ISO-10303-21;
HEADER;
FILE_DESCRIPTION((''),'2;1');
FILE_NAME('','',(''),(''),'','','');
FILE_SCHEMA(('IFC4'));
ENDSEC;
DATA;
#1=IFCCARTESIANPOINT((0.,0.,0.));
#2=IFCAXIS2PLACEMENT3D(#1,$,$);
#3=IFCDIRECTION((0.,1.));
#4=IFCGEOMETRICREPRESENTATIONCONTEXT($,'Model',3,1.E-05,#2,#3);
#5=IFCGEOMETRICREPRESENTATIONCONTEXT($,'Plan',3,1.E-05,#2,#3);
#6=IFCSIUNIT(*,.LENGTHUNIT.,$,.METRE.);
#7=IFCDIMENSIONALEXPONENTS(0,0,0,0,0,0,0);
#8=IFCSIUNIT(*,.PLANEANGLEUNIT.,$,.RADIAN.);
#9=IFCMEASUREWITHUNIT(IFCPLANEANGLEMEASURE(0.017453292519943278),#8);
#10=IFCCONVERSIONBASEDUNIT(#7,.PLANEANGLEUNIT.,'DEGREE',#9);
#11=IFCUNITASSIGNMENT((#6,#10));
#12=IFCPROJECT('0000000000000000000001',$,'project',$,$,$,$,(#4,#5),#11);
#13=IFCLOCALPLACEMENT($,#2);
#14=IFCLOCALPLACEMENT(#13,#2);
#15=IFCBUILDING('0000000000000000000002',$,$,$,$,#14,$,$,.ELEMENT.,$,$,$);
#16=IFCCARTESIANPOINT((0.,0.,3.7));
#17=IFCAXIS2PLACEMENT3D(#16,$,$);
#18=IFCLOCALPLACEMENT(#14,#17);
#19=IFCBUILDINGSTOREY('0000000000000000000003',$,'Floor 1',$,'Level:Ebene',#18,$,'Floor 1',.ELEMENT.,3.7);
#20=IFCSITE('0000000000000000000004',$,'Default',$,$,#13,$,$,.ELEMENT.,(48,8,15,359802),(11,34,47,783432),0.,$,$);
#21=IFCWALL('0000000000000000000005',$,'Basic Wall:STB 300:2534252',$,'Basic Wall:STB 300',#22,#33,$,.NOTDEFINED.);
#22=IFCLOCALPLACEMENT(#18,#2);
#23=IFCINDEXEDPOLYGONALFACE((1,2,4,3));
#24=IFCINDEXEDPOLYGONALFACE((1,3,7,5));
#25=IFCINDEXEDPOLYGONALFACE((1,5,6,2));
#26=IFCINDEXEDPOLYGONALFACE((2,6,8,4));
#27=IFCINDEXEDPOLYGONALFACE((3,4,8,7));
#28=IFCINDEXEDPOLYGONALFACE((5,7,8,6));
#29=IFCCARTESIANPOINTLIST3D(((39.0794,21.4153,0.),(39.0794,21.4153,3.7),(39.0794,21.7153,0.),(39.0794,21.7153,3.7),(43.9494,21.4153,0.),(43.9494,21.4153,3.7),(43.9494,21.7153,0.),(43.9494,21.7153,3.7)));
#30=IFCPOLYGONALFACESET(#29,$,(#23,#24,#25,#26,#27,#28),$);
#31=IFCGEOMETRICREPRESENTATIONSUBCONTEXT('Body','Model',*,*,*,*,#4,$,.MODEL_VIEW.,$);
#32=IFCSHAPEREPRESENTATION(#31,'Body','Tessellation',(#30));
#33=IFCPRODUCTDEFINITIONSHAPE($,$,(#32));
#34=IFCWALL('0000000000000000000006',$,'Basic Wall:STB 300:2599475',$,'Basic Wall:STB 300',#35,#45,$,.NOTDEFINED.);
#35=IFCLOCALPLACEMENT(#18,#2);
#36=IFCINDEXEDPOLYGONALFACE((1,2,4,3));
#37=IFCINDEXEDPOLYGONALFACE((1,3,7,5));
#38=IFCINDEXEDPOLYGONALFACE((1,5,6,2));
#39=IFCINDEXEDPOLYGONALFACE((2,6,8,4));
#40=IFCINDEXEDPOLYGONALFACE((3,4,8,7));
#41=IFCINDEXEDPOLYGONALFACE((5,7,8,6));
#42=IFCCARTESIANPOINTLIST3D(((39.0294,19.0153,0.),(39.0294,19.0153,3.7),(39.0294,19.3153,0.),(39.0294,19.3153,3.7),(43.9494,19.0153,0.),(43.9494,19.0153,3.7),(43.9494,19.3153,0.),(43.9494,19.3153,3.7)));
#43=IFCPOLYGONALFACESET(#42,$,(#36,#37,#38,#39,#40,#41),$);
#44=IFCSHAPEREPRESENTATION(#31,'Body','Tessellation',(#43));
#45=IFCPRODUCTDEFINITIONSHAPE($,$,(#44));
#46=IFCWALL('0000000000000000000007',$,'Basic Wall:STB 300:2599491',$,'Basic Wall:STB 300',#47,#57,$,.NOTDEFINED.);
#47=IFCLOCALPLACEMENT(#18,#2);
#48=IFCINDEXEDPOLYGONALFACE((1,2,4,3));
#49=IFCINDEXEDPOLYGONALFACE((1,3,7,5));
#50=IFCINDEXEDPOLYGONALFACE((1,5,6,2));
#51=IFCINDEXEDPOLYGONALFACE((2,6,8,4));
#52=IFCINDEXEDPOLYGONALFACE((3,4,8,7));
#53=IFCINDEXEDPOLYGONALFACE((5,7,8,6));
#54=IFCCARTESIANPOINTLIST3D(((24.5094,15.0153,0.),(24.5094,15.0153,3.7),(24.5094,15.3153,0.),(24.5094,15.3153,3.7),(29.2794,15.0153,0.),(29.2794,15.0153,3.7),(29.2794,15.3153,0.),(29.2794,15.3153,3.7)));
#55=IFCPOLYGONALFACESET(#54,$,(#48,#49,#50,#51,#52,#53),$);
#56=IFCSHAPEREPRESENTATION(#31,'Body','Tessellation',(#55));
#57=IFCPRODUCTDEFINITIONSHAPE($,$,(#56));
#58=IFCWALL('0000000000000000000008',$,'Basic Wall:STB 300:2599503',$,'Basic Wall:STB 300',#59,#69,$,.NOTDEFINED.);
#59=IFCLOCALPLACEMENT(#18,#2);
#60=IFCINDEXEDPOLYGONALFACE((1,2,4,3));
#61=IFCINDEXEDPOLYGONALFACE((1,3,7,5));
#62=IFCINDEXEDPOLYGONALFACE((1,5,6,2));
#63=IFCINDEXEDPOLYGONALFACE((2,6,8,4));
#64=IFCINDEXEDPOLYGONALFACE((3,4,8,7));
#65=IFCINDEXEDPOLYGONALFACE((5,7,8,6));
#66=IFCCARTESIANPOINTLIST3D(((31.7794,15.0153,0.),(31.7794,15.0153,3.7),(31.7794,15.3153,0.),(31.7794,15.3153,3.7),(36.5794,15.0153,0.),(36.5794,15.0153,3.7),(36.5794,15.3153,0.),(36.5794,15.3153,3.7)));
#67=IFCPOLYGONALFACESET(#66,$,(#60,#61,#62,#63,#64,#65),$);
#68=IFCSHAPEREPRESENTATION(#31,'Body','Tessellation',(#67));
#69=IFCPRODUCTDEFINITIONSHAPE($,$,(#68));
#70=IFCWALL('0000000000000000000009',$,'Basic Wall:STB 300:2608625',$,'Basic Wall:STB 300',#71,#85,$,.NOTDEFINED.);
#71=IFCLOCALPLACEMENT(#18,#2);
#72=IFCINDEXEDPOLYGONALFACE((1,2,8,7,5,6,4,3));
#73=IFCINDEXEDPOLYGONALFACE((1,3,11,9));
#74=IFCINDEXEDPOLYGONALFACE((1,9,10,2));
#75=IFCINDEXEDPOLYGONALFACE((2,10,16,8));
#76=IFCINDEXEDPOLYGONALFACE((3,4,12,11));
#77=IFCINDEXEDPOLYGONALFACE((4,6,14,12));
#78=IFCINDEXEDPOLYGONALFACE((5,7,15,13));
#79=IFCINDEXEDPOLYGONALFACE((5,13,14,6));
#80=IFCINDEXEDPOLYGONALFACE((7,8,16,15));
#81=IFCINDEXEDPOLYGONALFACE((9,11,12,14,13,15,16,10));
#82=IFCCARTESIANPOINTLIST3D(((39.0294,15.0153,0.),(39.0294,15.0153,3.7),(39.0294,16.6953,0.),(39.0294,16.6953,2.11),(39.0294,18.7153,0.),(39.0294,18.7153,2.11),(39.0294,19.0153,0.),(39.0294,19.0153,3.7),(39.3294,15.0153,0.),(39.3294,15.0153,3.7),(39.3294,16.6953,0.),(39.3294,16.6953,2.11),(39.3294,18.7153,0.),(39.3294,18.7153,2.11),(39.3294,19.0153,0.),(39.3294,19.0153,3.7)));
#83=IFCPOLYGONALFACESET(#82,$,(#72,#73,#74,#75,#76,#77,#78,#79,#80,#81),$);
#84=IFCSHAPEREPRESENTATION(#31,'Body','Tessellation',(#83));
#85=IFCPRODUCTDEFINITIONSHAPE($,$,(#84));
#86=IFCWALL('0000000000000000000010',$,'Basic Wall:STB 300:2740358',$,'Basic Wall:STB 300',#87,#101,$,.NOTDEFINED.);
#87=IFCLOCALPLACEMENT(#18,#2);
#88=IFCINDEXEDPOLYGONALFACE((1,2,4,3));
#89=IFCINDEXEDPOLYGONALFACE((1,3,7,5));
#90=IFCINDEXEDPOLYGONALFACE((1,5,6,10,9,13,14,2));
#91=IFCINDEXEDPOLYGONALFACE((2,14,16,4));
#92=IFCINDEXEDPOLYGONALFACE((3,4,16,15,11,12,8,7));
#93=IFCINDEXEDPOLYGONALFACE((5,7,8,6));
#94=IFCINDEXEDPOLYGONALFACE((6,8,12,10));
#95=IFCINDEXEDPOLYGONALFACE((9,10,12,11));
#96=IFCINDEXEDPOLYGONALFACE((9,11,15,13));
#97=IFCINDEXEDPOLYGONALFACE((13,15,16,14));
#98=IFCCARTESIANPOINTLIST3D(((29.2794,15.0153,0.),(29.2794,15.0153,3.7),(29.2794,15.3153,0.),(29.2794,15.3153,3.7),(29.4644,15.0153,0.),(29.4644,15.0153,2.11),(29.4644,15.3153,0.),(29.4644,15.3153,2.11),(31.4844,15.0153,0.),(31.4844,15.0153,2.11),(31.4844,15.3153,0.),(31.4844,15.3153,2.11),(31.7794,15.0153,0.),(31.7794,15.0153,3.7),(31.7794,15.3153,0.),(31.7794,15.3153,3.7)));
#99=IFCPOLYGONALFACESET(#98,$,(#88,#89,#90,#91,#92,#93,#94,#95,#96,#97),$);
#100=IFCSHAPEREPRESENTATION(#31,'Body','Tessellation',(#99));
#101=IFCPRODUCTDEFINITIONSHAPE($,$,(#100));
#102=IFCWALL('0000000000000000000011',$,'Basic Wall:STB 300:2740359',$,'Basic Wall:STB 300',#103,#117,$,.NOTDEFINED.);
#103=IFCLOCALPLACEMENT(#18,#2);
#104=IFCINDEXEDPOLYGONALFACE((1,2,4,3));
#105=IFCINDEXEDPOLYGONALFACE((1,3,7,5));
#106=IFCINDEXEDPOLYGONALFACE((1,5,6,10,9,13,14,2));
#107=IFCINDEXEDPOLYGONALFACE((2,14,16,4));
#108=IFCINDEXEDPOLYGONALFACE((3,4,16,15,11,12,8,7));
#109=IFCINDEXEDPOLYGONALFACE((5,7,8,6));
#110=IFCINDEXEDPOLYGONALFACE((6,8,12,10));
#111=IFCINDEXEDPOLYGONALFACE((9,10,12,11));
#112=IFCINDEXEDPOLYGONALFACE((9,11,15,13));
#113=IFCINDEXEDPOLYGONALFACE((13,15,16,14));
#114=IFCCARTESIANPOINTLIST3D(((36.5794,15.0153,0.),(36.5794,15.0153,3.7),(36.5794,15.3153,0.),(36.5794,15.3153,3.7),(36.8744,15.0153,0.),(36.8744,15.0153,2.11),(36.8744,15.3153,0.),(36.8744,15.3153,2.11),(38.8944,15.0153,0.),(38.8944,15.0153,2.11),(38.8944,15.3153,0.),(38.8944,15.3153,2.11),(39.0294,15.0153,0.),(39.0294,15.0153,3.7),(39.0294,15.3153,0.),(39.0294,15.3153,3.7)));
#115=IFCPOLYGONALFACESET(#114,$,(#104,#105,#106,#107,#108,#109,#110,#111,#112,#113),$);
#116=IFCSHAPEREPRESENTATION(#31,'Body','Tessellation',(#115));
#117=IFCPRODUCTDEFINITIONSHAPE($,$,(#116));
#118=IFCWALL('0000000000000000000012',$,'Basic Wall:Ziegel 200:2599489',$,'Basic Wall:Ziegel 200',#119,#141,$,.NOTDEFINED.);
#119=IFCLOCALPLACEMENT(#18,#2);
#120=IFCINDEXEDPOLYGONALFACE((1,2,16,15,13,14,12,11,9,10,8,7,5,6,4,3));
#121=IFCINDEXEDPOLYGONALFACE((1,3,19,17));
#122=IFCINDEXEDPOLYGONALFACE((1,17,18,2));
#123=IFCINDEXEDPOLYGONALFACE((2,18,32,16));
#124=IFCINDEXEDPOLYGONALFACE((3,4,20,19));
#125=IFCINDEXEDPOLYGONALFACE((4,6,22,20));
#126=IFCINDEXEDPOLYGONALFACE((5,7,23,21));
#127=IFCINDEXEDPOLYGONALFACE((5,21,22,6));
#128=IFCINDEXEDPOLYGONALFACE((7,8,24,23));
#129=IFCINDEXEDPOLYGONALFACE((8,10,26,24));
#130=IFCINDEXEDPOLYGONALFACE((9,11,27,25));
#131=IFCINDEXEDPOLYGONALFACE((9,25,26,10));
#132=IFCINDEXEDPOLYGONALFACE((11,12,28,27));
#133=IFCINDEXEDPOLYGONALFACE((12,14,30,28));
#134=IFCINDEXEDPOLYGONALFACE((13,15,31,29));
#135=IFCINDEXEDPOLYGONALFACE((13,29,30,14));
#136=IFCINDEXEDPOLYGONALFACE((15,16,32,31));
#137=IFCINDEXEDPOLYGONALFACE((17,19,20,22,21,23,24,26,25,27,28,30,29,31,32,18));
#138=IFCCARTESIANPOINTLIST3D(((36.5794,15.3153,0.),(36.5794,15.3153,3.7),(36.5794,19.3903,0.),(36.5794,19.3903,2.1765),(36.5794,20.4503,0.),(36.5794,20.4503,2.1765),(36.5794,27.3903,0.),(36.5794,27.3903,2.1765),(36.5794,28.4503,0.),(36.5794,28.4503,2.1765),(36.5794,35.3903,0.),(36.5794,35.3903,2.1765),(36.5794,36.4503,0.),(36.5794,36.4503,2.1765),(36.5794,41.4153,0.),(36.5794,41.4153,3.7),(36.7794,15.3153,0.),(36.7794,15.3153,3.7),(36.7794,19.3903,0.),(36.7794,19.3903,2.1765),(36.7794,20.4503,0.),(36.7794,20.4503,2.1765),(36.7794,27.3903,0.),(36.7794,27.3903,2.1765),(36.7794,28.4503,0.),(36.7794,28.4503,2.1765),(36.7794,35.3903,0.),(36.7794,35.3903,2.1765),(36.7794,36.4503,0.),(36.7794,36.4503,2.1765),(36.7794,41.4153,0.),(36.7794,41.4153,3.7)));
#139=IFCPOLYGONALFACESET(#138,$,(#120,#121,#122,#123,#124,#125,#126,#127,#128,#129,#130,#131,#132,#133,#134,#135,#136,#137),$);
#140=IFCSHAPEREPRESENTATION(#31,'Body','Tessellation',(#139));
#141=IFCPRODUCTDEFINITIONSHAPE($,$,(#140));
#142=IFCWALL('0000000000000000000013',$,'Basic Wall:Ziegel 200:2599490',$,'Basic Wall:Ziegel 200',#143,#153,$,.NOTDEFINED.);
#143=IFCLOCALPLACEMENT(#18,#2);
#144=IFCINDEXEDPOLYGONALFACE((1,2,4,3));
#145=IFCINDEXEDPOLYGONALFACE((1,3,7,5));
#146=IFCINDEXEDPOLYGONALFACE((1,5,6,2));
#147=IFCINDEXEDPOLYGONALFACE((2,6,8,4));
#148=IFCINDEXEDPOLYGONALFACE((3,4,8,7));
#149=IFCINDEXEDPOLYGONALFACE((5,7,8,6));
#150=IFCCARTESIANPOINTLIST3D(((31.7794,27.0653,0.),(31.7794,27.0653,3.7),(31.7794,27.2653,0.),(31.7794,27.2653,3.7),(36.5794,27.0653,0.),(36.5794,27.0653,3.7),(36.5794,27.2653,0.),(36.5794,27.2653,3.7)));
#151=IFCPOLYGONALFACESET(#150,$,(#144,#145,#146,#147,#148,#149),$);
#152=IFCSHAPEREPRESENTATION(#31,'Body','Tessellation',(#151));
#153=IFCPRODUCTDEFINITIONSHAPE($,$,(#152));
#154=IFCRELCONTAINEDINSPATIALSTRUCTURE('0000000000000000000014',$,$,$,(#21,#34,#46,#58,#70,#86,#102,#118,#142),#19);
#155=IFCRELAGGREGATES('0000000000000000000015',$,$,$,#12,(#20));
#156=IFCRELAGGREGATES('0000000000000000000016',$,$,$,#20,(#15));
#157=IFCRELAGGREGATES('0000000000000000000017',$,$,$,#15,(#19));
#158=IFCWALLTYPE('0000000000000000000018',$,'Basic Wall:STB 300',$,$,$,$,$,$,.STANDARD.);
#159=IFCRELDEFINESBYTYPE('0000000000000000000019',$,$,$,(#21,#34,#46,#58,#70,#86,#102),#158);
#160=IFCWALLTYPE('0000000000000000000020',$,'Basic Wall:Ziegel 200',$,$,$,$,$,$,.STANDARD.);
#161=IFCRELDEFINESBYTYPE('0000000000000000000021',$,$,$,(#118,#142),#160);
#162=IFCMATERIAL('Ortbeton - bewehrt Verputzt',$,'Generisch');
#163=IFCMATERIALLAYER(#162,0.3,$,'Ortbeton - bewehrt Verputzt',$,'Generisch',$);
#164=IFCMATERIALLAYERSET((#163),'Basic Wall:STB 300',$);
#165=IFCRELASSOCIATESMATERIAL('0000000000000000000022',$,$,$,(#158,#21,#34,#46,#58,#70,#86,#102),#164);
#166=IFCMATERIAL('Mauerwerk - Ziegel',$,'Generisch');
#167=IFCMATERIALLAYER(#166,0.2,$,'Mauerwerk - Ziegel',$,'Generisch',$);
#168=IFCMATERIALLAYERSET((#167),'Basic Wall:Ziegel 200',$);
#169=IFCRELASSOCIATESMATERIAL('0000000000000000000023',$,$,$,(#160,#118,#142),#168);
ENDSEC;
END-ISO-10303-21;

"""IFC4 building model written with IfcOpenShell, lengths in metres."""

from ifc_helpers import new_model, entity, si_unit, converted_unit, direction, frame, frame_2d, origin, place, context, subcontext, project, spatial, rectangle, extrude, material, layer, layer_set, layer_usage, type_object, element, save


model = new_model("IFC4")

# Units and contexts
model_context = context("Model", 3, precision=1e-05, world=origin(), true_north=direction((0.0, 1.0)))
plan_context = context("Plan", 3, precision=1e-05, world=origin(), true_north=direction((0.0, 1.0)))
body_context = subcontext(model_context, "Body", "Model", "MODEL_VIEW")
ifc_project = project(units=[si_unit("LENGTHUNIT", "METRE"), converted_unit("PLANEANGLEUNIT", "DEGREE", entity("IfcPlaneAngleMeasure", 0.017453292519943278), si_unit("PLANEANGLEUNIT", "RADIAN"), dimensions=[0, 0, 0, 0, 0, 0, 0])], contexts=[model_context, plan_context])

# Site, building, storey
site_placement = place(None, origin())
site = spatial("IfcSite", under=ifc_project, at=site_placement, Name="Default", CompositionType="ELEMENT", RefLatitude=(48, 8, 15, 359802), RefLongitude=(11, 34, 47, 783432), RefElevation=0.0)
building_placement = place(site_placement, origin())
building = spatial("IfcBuilding", under=site, at=building_placement, CompositionType="ELEMENT")
storey_placement = place(building_placement, frame((0.0, 0.0, 3.7)))
storey = spatial("IfcBuildingStorey", under=building, at=storey_placement, Name="Floor 1", ObjectType="Level:Ebene", LongName="Floor 1", CompositionType="ELEMENT", Elevation=3.7)

# Walls
ifc_material_1 = material(Name="Ortbeton - bewehrt Verputzt", Category="Generisch")
ifc_layer_1 = layer(ifc_material_1, 0.3, Name="Ortbeton - bewehrt Verputzt", Category="Generisch")
ifc_layer_set_1 = layer_set([ifc_layer_1], Name="Basic Wall:STB 300")
ifc_layer_usage_1 = layer_usage(ifc_layer_set_1, "AXIS2", "NEGATIVE", 0.15)
wall_type_1 = type_object("IfcWallType", Name="Basic Wall:STB 300", PredefinedType="STANDARD", material=ifc_layer_set_1)
wall_1_placement = place(storey_placement, frame((39.0794, 21.5653, 0.0)))
element("IfcWall", 1, at=wall_1_placement, inside=storey, type_object=wall_type_1, material=ifc_layer_usage_1, Name="Basic Wall:STB 300:2534252", ObjectType="Basic Wall:STB 300", PredefinedType="NOTDEFINED", context=body_context, shape_type="SweptSolid", body=[
    extrude(rectangle(XDim=4.87, YDim=0.3, at=frame_2d((2.435, 0.0), x_axis=(-1.0, 0.0))), origin(), (0.0, 0.0, 1.0), 3.7),
])
wall_2_placement = place(storey_placement, frame((43.9494, 19.1653, 0.0), z_axis=(0.0, 0.0, 1.0), x_axis=(-1.0, 0.0, 0.0)))
element("IfcWall", 2, at=wall_2_placement, inside=storey, type_object=wall_type_1, material=ifc_layer_usage_1, Name="Basic Wall:STB 300:2599475", ObjectType="Basic Wall:STB 300", PredefinedType="NOTDEFINED", context=body_context, shape_type="SweptSolid", body=[
    extrude(rectangle(XDim=4.92, YDim=0.3, at=frame_2d((2.46, 0.0), x_axis=(-1.0, 0.0))), origin(), (0.0, 0.0, 1.0), 3.7),
])
wall_3_placement = place(storey_placement, frame((24.5094, 15.1653, 0.0)))
element("IfcWall", 3, at=wall_3_placement, inside=storey, type_object=wall_type_1, material=ifc_layer_usage_1, Name="Basic Wall:STB 300:2599491", ObjectType="Basic Wall:STB 300", PredefinedType="NOTDEFINED", context=body_context, shape_type="SweptSolid", body=[
    extrude(rectangle(XDim=4.77, YDim=0.3, at=frame_2d((2.385, 0.0), x_axis=(-1.0, 0.0))), origin(), (0.0, 0.0, 1.0), 3.7),
])
wall_4_placement = place(storey_placement, frame((31.7794, 15.1653, 0.0)))
element("IfcWall", 4, at=wall_4_placement, inside=storey, type_object=wall_type_1, material=ifc_layer_usage_1, Name="Basic Wall:STB 300:2599503", ObjectType="Basic Wall:STB 300", PredefinedType="NOTDEFINED", context=body_context, shape_type="SweptSolid", body=[
    extrude(rectangle(XDim=4.8, YDim=0.3, at=frame_2d((2.4, 0.0), x_axis=(-1.0, 0.0))), origin(), (0.0, 0.0, 1.0), 3.7),
])

# Walls, openings
wall_5_placement = place(storey_placement, frame((39.1794, 19.0153, 0.0), z_axis=(0.0, 0.0, 1.0), x_axis=(0.0, -1.0, 0.0)))
wall_5 = element("IfcWall", 5, at=wall_5_placement, inside=storey, type_object=wall_type_1, material=ifc_layer_usage_1, Name="Basic Wall:STB 300:2608625", ObjectType="Basic Wall:STB 300", PredefinedType="NOTDEFINED", context=body_context, shape_type="SweptSolid", body=[
    extrude(rectangle(XDim=4.0, YDim=0.3, at=frame_2d((2.0, 0.0), x_axis=(1.0, 0.0))), origin(), (0.0, 0.0, 1.0), 3.7),
])
opening_1_placement = place(wall_5_placement, frame((2.32, 0.15, 0.0)))
element("IfcOpeningElement", 6, at=opening_1_placement, cuts=wall_5, PredefinedType="OPENING", context=body_context, shape_type="SweptSolid", body=[
    extrude(rectangle(XDim=2.11, YDim=2.02, at=frame_2d((1.055, 1.01), x_axis=(1.0, 0.0))), frame((0.0, 0.0, 0.0), z_axis=(0.0, -1.0, 0.0), x_axis=(0.0, 0.0, 1.0)), (0.0, 0.0, 1.0), 0.3),
])
wall_6_placement = place(storey_placement, frame((29.2794, 15.1653, 0.0)))
wall_6 = element("IfcWall", 7, at=wall_6_placement, inside=storey, type_object=wall_type_1, material=ifc_layer_usage_1, Name="Basic Wall:STB 300:2740358", ObjectType="Basic Wall:STB 300", PredefinedType="NOTDEFINED", context=body_context, shape_type="SweptSolid", body=[
    extrude(rectangle(XDim=2.5, YDim=0.3, at=frame_2d((1.25, 0.0), x_axis=(-1.0, 0.0))), origin(), (0.0, 0.0, 1.0), 3.7),
])
opening_2_placement = place(wall_6_placement, frame((0.185, -0.15, 0.0)))
element("IfcOpeningElement", 8, at=opening_2_placement, cuts=wall_6, PredefinedType="OPENING", context=body_context, shape_type="SweptSolid", body=[
    extrude(rectangle(XDim=2.11, YDim=2.02, at=frame_2d((1.055, 1.01), x_axis=(1.0, 0.0))), frame((0.0, 0.0, 0.0), z_axis=(0.0, 1.0, 0.0), x_axis=(0.0, 0.0, 1.0)), (0.0, 0.0, 1.0), 0.3),
])
wall_7_placement = place(storey_placement, frame((36.5794, 15.1653, 0.0)))
wall_7 = element("IfcWall", 9, at=wall_7_placement, inside=storey, type_object=wall_type_1, material=ifc_layer_usage_1, Name="Basic Wall:STB 300:2740359", ObjectType="Basic Wall:STB 300", PredefinedType="NOTDEFINED", context=body_context, shape_type="SweptSolid", body=[
    extrude(rectangle(XDim=2.45, YDim=0.3, at=frame_2d((1.225, 0.0), x_axis=(-1.0, 0.0))), origin(), (0.0, 0.0, 1.0), 3.7),
])
opening_3_placement = place(wall_7_placement, frame((0.295, -0.15, 0.0)))
element("IfcOpeningElement", 10, at=opening_3_placement, cuts=wall_7, PredefinedType="OPENING", context=body_context, shape_type="SweptSolid", body=[
    extrude(rectangle(XDim=2.11, YDim=2.02, at=frame_2d((1.055, 1.01), x_axis=(1.0, 0.0))), frame((0.0, 0.0, 0.0), z_axis=(0.0, 1.0, 0.0), x_axis=(0.0, 0.0, 1.0)), (0.0, 0.0, 1.0), 0.3),
])

# Wall, openings
ifc_material_2 = material(Name="Mauerwerk - Ziegel", Category="Generisch")
ifc_layer_2 = layer(ifc_material_2, 0.2, Name="Mauerwerk - Ziegel", Category="Generisch")
ifc_layer_set_2 = layer_set([ifc_layer_2], Name="Basic Wall:Ziegel 200")
ifc_layer_usage_2 = layer_usage(ifc_layer_set_2, "AXIS2", "NEGATIVE", 0.1)
wall_type_2 = type_object("IfcWallType", Name="Basic Wall:Ziegel 200", PredefinedType="STANDARD", material=ifc_layer_set_2)
wall_8_placement = place(storey_placement, frame((36.6794, 15.3153, 0.0), z_axis=(0.0, 0.0, 1.0), x_axis=(0.0, 1.0, 0.0)))
wall_8 = element("IfcWall", 11, at=wall_8_placement, inside=storey, type_object=wall_type_2, material=ifc_layer_usage_2, Name="Basic Wall:Ziegel 200:2599489", ObjectType="Basic Wall:Ziegel 200", PredefinedType="NOTDEFINED", context=body_context, shape_type="SweptSolid", body=[
    extrude(rectangle(XDim=26.1, YDim=0.2, at=frame_2d((13.05, 0.0), x_axis=(-1.0, 0.0))), origin(), (0.0, 0.0, 1.0), 3.7),
])
opening_4_placement = place(wall_8_placement, frame((5.135, 0.1, 0.0)))
element("IfcOpeningElement", 12, at=opening_4_placement, cuts=wall_8, PredefinedType="OPENING", context=body_context, shape_type="SweptSolid", body=[
    extrude(rectangle(XDim=2.1765, YDim=1.06, at=frame_2d((1.0882, 0.53), x_axis=(1.0, 0.0))), frame((0.0, 0.0, 0.0), z_axis=(0.0, -1.0, 0.0), x_axis=(0.0, 0.0, 1.0)), (0.0, 0.0, 1.0), 0.2),
])
opening_5_placement = place(wall_8_placement, frame((21.135, 0.1, 0.0)))
element("IfcOpeningElement", 13, at=opening_5_placement, cuts=wall_8, PredefinedType="OPENING", context=body_context, shape_type="SweptSolid", body=[
    extrude(rectangle(XDim=2.1765, YDim=1.06, at=frame_2d((1.0882, 0.53), x_axis=(1.0, 0.0))), frame((0.0, 0.0, 0.0), z_axis=(0.0, -1.0, 0.0), x_axis=(0.0, 0.0, 1.0)), (0.0, 0.0, 1.0), 0.2),
])
opening_6_placement = place(wall_8_placement, frame((13.135, 0.1, 0.0)))
element("IfcOpeningElement", 14, at=opening_6_placement, cuts=wall_8, PredefinedType="OPENING", context=body_context, shape_type="SweptSolid", body=[
    extrude(rectangle(XDim=2.1765, YDim=1.06, at=frame_2d((1.0882, 0.53), x_axis=(1.0, 0.0))), frame((0.0, 0.0, 0.0), z_axis=(0.0, -1.0, 0.0), x_axis=(0.0, 0.0, 1.0)), (0.0, 0.0, 1.0), 0.2),
])

# Wall
wall_9_placement = place(storey_placement, frame((31.7794, 27.1653, 0.0)))
element("IfcWall", 15, at=wall_9_placement, inside=storey, type_object=wall_type_2, material=ifc_layer_usage_2, Name="Basic Wall:Ziegel 200:2599490", ObjectType="Basic Wall:Ziegel 200", PredefinedType="NOTDEFINED", context=body_context, shape_type="SweptSolid", body=[
    extrude(rectangle(XDim=4.8, YDim=0.2, at=frame_2d((2.4, 0.0), x_axis=(-1.0, 0.0))), origin(), (0.0, 0.0, 1.0), 3.7),
])

save(model, "model.ifc")
